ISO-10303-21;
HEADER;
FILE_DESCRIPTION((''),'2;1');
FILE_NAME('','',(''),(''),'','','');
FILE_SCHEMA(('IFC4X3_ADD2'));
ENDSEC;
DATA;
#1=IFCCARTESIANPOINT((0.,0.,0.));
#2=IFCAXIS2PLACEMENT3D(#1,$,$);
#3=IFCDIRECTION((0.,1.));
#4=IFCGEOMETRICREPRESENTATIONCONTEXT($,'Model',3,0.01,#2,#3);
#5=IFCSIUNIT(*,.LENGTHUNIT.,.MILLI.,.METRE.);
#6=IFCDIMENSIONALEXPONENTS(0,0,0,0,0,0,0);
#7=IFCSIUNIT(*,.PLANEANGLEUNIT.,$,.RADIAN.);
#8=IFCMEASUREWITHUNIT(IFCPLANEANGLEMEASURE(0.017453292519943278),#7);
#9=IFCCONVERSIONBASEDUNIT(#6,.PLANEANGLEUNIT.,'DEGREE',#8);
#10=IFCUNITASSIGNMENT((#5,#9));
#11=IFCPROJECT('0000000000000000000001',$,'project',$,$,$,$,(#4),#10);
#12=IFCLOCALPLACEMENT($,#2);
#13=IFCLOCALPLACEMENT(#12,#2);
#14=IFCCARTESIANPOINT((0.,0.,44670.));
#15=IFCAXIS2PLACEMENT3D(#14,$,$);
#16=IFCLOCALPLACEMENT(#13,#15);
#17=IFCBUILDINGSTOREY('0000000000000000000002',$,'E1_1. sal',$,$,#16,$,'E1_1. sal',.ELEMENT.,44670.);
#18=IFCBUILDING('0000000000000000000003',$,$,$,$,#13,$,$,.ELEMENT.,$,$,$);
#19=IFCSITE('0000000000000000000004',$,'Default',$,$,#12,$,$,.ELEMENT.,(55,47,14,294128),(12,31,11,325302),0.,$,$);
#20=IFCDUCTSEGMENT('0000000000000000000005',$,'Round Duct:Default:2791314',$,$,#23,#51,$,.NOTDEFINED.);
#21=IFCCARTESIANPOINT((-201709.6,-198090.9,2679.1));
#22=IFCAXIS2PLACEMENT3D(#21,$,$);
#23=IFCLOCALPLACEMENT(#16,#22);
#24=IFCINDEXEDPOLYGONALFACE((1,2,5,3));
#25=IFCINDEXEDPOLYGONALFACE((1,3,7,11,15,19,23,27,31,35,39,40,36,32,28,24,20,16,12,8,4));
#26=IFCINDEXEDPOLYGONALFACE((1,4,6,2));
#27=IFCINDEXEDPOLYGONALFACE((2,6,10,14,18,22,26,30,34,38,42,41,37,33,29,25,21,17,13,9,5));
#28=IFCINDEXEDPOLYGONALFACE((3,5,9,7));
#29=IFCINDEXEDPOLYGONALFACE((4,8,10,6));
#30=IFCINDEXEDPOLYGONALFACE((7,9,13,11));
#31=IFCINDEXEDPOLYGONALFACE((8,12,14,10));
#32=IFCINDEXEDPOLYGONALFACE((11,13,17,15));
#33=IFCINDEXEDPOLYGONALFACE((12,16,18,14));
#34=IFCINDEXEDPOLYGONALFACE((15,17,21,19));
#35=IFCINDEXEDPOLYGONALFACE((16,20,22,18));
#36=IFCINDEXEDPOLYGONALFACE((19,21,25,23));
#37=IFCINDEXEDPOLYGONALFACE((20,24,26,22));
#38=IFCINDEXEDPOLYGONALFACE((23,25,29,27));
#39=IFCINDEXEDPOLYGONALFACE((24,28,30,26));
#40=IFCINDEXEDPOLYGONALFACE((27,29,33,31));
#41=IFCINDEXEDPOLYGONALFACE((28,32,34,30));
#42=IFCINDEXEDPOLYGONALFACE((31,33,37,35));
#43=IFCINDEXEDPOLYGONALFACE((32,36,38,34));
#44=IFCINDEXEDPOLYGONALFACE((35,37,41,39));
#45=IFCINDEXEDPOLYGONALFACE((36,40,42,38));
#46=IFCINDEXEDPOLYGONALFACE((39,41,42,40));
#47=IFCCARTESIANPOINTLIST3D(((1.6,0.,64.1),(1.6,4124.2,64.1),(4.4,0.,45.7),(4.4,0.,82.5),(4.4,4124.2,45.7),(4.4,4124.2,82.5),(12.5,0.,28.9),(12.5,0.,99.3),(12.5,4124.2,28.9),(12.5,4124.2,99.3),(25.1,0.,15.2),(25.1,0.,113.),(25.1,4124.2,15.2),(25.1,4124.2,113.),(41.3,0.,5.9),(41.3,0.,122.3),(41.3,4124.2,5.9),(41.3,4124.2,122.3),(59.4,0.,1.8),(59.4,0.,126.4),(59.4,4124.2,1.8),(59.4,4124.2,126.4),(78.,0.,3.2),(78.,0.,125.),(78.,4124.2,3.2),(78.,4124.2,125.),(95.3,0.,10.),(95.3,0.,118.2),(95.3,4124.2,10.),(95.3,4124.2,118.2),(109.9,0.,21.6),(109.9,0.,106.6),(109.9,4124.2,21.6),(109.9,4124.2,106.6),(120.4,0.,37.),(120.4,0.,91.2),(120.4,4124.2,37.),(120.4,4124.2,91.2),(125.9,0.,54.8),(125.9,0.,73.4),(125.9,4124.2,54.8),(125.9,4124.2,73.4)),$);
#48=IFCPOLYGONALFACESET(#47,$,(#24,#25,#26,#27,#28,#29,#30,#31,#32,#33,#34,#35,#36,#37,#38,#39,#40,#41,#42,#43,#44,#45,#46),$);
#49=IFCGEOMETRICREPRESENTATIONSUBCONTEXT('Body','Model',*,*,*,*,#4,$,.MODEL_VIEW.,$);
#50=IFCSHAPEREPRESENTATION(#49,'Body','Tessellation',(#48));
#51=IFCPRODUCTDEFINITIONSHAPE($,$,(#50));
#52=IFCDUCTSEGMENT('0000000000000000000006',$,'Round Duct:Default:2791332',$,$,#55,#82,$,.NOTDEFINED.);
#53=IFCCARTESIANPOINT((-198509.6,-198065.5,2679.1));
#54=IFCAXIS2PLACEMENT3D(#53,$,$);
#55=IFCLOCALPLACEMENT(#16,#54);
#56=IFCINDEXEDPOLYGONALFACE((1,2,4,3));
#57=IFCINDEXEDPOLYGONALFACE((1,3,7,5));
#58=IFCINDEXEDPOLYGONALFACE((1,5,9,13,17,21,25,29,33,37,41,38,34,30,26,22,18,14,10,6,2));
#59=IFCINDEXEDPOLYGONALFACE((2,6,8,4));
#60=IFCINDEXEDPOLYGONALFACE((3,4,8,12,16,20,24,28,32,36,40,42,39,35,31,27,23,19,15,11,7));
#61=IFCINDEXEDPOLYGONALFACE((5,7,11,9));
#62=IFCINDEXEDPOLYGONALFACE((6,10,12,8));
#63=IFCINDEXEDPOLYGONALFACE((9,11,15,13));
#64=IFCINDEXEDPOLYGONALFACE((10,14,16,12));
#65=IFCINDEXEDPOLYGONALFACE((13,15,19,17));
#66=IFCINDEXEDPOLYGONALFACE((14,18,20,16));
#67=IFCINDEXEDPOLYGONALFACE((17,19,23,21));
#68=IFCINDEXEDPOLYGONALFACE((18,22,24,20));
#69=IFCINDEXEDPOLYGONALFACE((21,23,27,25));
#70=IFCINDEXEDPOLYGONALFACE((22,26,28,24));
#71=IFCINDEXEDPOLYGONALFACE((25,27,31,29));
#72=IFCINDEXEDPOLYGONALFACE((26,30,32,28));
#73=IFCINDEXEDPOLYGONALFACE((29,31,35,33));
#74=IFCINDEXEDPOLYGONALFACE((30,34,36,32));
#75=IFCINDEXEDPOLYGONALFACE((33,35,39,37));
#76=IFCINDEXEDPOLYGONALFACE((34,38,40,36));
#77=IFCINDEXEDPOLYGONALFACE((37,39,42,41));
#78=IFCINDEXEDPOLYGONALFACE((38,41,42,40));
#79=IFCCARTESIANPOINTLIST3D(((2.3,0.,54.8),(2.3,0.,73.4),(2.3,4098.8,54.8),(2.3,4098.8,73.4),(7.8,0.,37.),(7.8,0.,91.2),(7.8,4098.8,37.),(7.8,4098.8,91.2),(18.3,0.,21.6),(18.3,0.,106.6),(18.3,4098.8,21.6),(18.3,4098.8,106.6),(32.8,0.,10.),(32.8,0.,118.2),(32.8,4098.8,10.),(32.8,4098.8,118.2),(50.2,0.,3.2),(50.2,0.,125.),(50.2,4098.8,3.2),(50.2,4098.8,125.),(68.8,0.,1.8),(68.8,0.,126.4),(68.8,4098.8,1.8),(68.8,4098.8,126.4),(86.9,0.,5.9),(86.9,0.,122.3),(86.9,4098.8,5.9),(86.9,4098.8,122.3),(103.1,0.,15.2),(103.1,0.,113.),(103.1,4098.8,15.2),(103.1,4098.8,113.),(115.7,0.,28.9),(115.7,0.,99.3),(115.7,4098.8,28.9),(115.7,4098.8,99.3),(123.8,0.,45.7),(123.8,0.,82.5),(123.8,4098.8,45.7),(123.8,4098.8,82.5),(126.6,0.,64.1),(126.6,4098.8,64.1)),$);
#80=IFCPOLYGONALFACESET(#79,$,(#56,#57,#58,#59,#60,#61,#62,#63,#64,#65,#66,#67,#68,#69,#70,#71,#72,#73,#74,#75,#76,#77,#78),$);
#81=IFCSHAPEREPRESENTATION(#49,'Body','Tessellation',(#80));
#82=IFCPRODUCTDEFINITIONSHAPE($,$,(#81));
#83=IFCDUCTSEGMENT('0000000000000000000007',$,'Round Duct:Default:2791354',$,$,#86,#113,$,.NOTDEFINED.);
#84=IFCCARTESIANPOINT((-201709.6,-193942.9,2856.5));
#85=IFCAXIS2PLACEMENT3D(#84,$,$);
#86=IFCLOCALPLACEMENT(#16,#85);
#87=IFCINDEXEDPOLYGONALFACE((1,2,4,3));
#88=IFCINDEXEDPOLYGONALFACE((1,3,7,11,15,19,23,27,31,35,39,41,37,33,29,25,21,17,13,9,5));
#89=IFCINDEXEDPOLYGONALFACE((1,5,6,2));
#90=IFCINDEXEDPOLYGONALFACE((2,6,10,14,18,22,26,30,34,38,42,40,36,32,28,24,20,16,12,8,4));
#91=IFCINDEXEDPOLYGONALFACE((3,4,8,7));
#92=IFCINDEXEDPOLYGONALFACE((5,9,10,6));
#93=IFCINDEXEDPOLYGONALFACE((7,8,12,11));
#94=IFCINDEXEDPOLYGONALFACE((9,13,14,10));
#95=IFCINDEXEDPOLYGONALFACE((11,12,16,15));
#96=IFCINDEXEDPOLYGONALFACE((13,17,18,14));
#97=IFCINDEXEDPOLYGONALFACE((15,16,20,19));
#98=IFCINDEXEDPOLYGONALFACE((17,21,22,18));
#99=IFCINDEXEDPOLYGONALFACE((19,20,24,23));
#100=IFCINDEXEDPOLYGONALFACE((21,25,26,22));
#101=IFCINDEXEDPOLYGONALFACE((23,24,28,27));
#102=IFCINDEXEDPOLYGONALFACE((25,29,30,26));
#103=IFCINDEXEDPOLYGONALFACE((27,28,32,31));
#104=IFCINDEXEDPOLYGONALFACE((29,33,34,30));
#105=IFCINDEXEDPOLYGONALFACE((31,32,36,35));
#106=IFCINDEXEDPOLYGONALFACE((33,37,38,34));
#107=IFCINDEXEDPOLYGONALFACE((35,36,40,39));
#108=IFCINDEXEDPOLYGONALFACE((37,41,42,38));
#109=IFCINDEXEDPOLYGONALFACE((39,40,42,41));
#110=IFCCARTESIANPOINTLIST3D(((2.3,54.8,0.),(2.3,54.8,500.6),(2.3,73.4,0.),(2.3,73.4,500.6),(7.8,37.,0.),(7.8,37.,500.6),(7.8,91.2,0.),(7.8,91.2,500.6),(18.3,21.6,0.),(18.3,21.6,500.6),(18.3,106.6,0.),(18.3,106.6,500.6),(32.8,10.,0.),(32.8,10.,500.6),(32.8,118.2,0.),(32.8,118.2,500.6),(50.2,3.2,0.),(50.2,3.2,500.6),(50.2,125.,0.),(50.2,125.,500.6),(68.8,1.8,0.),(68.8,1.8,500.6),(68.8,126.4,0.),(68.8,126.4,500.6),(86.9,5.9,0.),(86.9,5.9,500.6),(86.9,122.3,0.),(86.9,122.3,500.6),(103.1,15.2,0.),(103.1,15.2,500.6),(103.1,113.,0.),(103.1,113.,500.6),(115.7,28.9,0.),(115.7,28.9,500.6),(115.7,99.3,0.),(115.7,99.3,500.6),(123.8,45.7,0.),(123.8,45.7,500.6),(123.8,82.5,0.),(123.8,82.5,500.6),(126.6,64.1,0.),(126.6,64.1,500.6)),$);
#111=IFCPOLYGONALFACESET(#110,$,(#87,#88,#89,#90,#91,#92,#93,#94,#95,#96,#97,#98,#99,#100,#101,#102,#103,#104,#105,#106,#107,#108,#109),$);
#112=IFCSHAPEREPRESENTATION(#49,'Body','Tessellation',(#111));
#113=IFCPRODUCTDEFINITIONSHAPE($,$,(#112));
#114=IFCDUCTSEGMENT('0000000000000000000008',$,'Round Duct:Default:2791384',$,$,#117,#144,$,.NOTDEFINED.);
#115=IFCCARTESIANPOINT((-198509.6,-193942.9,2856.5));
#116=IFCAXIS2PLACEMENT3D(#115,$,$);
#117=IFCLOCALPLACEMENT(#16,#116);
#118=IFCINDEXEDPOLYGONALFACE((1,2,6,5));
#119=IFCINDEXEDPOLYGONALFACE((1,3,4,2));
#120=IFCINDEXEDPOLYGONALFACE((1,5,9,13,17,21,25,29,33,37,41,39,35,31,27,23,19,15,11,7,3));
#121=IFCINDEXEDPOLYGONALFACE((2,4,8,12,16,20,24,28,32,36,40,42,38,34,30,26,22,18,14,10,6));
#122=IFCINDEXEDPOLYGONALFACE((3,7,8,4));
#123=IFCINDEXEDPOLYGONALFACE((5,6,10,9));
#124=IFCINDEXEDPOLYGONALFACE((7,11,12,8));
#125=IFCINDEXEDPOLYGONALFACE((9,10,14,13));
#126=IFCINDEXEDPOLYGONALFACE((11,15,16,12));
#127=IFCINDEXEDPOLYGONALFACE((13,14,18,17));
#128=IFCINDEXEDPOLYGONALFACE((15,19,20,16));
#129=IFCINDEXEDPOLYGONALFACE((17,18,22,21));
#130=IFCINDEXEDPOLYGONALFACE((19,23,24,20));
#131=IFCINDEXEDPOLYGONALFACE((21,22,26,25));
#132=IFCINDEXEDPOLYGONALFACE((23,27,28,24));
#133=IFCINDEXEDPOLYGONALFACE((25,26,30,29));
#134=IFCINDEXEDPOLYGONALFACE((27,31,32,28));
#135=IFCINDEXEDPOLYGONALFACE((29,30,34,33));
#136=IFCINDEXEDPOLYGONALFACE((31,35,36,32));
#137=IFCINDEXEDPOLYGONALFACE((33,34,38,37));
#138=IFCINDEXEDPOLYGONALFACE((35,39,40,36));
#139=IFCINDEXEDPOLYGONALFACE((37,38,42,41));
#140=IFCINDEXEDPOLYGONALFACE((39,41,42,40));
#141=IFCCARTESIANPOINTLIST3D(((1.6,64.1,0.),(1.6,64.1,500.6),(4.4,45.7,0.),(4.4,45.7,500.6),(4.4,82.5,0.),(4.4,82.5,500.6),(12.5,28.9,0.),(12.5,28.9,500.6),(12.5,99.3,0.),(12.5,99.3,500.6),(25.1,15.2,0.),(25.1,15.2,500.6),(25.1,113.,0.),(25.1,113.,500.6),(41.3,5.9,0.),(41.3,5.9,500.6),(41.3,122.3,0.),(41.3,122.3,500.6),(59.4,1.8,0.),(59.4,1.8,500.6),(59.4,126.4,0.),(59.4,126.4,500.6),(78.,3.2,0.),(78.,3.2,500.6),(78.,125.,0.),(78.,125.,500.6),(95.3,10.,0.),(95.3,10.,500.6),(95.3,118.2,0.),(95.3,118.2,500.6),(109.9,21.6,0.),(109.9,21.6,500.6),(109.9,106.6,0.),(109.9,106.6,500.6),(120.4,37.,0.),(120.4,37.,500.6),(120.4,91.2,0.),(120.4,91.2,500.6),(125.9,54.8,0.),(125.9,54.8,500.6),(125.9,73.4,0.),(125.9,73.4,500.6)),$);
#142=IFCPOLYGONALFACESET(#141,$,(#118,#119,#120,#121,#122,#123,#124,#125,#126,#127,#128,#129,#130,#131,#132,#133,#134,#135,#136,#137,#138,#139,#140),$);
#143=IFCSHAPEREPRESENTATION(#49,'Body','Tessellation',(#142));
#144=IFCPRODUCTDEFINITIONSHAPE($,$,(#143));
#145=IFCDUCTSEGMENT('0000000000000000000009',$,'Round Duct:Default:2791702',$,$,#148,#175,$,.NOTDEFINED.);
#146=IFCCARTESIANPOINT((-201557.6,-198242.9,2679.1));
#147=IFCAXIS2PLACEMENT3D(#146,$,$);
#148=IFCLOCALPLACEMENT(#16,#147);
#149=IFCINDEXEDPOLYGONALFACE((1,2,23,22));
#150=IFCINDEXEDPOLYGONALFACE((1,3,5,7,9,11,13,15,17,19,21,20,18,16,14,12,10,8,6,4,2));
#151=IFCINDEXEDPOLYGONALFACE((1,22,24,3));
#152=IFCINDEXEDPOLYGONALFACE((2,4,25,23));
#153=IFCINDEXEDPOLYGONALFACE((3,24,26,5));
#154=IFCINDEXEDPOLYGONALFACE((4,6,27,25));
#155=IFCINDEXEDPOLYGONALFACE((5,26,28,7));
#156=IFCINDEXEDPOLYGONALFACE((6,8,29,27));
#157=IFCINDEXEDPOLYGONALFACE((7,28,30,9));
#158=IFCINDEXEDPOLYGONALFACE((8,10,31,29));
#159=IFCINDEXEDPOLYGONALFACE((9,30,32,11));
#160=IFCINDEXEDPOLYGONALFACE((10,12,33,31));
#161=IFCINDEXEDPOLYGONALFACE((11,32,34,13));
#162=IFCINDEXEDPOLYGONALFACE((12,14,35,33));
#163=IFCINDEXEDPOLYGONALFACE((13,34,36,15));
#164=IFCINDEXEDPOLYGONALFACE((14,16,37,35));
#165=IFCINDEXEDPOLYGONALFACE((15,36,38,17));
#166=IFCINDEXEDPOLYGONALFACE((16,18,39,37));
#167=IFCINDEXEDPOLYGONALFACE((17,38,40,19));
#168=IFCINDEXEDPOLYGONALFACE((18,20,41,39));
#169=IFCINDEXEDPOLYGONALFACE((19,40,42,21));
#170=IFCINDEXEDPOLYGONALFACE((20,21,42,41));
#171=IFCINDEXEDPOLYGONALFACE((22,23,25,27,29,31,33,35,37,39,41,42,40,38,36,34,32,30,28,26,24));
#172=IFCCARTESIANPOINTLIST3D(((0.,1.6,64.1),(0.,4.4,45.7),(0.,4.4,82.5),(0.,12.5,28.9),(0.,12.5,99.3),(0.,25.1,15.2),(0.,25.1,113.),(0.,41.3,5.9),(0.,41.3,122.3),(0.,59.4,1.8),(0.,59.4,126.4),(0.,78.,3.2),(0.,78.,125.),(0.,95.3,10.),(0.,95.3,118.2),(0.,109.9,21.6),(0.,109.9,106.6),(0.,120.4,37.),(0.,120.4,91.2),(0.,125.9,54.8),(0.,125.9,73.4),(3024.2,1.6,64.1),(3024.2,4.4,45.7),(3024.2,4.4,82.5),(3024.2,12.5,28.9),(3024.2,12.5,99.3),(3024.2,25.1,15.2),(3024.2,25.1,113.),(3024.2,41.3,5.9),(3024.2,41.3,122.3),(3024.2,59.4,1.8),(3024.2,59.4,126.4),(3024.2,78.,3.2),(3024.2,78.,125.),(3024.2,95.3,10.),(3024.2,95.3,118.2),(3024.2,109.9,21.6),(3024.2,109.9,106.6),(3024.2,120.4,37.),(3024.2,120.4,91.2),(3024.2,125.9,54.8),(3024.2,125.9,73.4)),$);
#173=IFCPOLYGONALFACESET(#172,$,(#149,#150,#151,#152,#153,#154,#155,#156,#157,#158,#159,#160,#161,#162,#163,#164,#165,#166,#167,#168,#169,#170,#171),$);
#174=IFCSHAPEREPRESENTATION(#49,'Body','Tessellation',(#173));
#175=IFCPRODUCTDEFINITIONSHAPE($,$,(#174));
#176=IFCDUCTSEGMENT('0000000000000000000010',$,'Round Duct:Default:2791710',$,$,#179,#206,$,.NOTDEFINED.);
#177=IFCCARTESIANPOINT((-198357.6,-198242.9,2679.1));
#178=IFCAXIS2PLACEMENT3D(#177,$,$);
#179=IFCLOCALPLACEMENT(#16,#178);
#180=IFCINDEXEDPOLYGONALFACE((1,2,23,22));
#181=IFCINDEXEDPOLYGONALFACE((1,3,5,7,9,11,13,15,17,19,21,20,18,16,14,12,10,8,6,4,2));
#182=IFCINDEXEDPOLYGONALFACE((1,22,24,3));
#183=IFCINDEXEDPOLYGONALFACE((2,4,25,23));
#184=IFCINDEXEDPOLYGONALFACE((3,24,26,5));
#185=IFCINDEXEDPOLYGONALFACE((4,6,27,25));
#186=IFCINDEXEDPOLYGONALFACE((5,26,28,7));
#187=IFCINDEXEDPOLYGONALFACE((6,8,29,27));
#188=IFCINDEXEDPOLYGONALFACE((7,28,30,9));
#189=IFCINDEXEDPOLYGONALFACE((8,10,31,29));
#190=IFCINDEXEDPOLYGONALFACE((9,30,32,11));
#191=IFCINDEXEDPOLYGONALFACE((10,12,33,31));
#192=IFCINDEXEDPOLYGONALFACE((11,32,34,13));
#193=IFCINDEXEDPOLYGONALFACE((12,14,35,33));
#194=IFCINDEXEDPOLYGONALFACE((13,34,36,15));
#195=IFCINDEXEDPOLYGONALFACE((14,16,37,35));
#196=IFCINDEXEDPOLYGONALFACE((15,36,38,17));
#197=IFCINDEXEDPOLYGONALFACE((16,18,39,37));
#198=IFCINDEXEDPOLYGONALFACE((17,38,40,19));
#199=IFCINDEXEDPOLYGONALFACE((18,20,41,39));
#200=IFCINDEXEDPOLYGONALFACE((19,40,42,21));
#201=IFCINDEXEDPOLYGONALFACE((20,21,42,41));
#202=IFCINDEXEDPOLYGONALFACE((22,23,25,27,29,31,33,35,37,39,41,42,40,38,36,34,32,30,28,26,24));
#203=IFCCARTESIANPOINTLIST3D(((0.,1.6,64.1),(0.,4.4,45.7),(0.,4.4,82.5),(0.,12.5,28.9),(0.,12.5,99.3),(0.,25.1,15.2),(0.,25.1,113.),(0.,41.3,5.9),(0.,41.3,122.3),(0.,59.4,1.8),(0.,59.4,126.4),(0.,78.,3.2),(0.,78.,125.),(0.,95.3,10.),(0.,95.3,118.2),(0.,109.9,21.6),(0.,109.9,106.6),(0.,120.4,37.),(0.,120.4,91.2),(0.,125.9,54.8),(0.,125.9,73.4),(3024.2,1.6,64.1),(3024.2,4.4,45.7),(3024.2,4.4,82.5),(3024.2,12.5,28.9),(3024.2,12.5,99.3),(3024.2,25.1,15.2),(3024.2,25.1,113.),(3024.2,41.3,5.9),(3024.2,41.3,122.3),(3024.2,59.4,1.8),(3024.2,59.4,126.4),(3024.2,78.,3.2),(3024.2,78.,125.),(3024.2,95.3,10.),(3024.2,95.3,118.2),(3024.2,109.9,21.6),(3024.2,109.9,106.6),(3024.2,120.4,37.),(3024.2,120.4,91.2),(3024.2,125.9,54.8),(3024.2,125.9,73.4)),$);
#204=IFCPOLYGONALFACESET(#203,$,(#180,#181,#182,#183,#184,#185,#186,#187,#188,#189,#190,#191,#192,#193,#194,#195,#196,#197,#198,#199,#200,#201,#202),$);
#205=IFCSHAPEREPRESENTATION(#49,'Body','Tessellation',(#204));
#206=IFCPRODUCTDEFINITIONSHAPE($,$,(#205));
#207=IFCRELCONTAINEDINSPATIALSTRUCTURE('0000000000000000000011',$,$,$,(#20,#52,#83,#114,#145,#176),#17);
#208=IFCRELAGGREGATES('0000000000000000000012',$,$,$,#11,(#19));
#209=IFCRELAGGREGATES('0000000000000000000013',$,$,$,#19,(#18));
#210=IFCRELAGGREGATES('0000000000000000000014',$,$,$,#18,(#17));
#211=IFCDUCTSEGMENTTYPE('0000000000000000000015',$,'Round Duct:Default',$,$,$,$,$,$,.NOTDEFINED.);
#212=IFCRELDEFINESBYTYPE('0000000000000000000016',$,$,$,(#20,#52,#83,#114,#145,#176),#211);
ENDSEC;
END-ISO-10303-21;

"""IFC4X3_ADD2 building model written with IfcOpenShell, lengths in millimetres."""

from ifc_helpers import new_model, entity, si_unit, converted_unit, direction, frame, origin, origin_2d_with_axis, place, context, subcontext, project, spatial, circle, extrude, type_object, element, save


model = new_model("IFC4X3_ADD2")

# Units and contexts
model_context = context("Model", 3, precision=0.01, world=origin(), true_north=direction((0.0, 1.0)))
body_context = subcontext(model_context, "Body", "Model", "MODEL_VIEW")
ifc_project = project(units=[si_unit("LENGTHUNIT", "METRE", prefix="MILLI"), converted_unit("PLANEANGLEUNIT", "DEGREE", entity("IfcPlaneAngleMeasure", 0.017453292519943278), si_unit("PLANEANGLEUNIT", "RADIAN"), dimensions=[0, 0, 0, 0, 0, 0, 0])], contexts=[model_context])

# Site, building, storey
site_placement = place(None, origin())
site = spatial("IfcSite", under=ifc_project, at=site_placement, Name="Default", CompositionType="ELEMENT", RefLatitude=(55, 47, 14, 294128), RefLongitude=(12, 31, 11, 325302), RefElevation=0.0)
building_placement = place(site_placement, origin())
building = spatial("IfcBuilding", under=site, at=building_placement, CompositionType="ELEMENT")
storey_placement = place(building_placement, frame((0.0, 0.0, 44670.0)))
storey = spatial("IfcBuildingStorey", under=building, at=storey_placement, Name="E1_1. sal", LongName="E1_1. sal", CompositionType="ELEMENT", Elevation=44670.0)

# Duct segments
duct_segment_type = type_object("IfcDuctSegmentType", Name="Round Duct:Default", PredefinedType="NOTDEFINED")
duct_segment_1_placement = place(storey_placement, frame((-201709.6, -198090.9, 2679.1)))
element("IfcDuctSegment", 1, at=duct_segment_1_placement, inside=storey, type_object=duct_segment_type, Name="Round Duct:Default:2791314", PredefinedType="NOTDEFINED", context=body_context, shape_type="SweptSolid", body=[
    extrude(circle(Radius=62.5, at=origin_2d_with_axis()), frame((64.1, 0.0, 64.1), z_axis=(0.0, 1.0, 0.0), x_axis=(-1.0, 0.0, 0.0)), (0.0, 0.0, 1.0), 4124.2),
])
duct_segment_2_placement = place(storey_placement, frame((-198509.6, -198065.5, 2679.1)))
element("IfcDuctSegment", 2, at=duct_segment_2_placement, inside=storey, type_object=duct_segment_type, Name="Round Duct:Default:2791332", PredefinedType="NOTDEFINED", context=body_context, shape_type="SweptSolid", body=[
    extrude(circle(Radius=62.5, at=origin_2d_with_axis()), frame((64.1, 0.0, 64.1), z_axis=(0.0, 1.0, 0.0), x_axis=(1.0, 0.0, 0.0)), (0.0, 0.0, 1.0), 4098.8),
])
duct_segment_3_placement = place(storey_placement, frame((-201709.6, -193942.9, 2856.5)))
element("IfcDuctSegment", 3, at=duct_segment_3_placement, inside=storey, type_object=duct_segment_type, Name="Round Duct:Default:2791354", PredefinedType="NOTDEFINED", context=body_context, shape_type="SweptSolid", body=[
    extrude(circle(Radius=62.5, at=origin_2d_with_axis()), frame((64.1, 64.1, 0.0)), (0.0, 0.0, 1.0), 500.6),
])
duct_segment_4_placement = place(storey_placement, frame((-198509.6, -193942.9, 2856.5)))
element("IfcDuctSegment", 4, at=duct_segment_4_placement, inside=storey, type_object=duct_segment_type, Name="Round Duct:Default:2791384", PredefinedType="NOTDEFINED", context=body_context, shape_type="SweptSolid", body=[
    extrude(circle(Radius=62.5, at=origin_2d_with_axis()), frame((64.1, 64.1, 0.0), z_axis=(0.0, 0.0, 1.0), x_axis=(-1.0, 0.0, 0.0)), (0.0, 0.0, 1.0), 500.6),
])
duct_segment_5_placement = place(storey_placement, frame((-201557.6, -198242.9, 2679.1)))
element("IfcDuctSegment", 5, at=duct_segment_5_placement, inside=storey, type_object=duct_segment_type, Name="Round Duct:Default:2791702", PredefinedType="NOTDEFINED", context=body_context, shape_type="SweptSolid", body=[
    extrude(circle(Radius=62.5, at=origin_2d_with_axis()), frame((0.0, 64.1, 64.1), z_axis=(1.0, 0.0, 0.0), x_axis=(0.0, -1.0, 0.0)), (0.0, 0.0, 1.0), 3024.2),
])
duct_segment_6_placement = place(storey_placement, frame((-198357.6, -198242.9, 2679.1)))
element("IfcDuctSegment", 6, at=duct_segment_6_placement, inside=storey, type_object=duct_segment_type, Name="Round Duct:Default:2791710", PredefinedType="NOTDEFINED", context=body_context, shape_type="SweptSolid", body=[
    extrude(circle(Radius=62.5, at=origin_2d_with_axis()), frame((0.0, 64.1, 64.1), z_axis=(1.0, 0.0, 0.0), x_axis=(0.0, -1.0, 0.0)), (0.0, 0.0, 1.0), 3024.2),
])

save(model, "model.ifc")
